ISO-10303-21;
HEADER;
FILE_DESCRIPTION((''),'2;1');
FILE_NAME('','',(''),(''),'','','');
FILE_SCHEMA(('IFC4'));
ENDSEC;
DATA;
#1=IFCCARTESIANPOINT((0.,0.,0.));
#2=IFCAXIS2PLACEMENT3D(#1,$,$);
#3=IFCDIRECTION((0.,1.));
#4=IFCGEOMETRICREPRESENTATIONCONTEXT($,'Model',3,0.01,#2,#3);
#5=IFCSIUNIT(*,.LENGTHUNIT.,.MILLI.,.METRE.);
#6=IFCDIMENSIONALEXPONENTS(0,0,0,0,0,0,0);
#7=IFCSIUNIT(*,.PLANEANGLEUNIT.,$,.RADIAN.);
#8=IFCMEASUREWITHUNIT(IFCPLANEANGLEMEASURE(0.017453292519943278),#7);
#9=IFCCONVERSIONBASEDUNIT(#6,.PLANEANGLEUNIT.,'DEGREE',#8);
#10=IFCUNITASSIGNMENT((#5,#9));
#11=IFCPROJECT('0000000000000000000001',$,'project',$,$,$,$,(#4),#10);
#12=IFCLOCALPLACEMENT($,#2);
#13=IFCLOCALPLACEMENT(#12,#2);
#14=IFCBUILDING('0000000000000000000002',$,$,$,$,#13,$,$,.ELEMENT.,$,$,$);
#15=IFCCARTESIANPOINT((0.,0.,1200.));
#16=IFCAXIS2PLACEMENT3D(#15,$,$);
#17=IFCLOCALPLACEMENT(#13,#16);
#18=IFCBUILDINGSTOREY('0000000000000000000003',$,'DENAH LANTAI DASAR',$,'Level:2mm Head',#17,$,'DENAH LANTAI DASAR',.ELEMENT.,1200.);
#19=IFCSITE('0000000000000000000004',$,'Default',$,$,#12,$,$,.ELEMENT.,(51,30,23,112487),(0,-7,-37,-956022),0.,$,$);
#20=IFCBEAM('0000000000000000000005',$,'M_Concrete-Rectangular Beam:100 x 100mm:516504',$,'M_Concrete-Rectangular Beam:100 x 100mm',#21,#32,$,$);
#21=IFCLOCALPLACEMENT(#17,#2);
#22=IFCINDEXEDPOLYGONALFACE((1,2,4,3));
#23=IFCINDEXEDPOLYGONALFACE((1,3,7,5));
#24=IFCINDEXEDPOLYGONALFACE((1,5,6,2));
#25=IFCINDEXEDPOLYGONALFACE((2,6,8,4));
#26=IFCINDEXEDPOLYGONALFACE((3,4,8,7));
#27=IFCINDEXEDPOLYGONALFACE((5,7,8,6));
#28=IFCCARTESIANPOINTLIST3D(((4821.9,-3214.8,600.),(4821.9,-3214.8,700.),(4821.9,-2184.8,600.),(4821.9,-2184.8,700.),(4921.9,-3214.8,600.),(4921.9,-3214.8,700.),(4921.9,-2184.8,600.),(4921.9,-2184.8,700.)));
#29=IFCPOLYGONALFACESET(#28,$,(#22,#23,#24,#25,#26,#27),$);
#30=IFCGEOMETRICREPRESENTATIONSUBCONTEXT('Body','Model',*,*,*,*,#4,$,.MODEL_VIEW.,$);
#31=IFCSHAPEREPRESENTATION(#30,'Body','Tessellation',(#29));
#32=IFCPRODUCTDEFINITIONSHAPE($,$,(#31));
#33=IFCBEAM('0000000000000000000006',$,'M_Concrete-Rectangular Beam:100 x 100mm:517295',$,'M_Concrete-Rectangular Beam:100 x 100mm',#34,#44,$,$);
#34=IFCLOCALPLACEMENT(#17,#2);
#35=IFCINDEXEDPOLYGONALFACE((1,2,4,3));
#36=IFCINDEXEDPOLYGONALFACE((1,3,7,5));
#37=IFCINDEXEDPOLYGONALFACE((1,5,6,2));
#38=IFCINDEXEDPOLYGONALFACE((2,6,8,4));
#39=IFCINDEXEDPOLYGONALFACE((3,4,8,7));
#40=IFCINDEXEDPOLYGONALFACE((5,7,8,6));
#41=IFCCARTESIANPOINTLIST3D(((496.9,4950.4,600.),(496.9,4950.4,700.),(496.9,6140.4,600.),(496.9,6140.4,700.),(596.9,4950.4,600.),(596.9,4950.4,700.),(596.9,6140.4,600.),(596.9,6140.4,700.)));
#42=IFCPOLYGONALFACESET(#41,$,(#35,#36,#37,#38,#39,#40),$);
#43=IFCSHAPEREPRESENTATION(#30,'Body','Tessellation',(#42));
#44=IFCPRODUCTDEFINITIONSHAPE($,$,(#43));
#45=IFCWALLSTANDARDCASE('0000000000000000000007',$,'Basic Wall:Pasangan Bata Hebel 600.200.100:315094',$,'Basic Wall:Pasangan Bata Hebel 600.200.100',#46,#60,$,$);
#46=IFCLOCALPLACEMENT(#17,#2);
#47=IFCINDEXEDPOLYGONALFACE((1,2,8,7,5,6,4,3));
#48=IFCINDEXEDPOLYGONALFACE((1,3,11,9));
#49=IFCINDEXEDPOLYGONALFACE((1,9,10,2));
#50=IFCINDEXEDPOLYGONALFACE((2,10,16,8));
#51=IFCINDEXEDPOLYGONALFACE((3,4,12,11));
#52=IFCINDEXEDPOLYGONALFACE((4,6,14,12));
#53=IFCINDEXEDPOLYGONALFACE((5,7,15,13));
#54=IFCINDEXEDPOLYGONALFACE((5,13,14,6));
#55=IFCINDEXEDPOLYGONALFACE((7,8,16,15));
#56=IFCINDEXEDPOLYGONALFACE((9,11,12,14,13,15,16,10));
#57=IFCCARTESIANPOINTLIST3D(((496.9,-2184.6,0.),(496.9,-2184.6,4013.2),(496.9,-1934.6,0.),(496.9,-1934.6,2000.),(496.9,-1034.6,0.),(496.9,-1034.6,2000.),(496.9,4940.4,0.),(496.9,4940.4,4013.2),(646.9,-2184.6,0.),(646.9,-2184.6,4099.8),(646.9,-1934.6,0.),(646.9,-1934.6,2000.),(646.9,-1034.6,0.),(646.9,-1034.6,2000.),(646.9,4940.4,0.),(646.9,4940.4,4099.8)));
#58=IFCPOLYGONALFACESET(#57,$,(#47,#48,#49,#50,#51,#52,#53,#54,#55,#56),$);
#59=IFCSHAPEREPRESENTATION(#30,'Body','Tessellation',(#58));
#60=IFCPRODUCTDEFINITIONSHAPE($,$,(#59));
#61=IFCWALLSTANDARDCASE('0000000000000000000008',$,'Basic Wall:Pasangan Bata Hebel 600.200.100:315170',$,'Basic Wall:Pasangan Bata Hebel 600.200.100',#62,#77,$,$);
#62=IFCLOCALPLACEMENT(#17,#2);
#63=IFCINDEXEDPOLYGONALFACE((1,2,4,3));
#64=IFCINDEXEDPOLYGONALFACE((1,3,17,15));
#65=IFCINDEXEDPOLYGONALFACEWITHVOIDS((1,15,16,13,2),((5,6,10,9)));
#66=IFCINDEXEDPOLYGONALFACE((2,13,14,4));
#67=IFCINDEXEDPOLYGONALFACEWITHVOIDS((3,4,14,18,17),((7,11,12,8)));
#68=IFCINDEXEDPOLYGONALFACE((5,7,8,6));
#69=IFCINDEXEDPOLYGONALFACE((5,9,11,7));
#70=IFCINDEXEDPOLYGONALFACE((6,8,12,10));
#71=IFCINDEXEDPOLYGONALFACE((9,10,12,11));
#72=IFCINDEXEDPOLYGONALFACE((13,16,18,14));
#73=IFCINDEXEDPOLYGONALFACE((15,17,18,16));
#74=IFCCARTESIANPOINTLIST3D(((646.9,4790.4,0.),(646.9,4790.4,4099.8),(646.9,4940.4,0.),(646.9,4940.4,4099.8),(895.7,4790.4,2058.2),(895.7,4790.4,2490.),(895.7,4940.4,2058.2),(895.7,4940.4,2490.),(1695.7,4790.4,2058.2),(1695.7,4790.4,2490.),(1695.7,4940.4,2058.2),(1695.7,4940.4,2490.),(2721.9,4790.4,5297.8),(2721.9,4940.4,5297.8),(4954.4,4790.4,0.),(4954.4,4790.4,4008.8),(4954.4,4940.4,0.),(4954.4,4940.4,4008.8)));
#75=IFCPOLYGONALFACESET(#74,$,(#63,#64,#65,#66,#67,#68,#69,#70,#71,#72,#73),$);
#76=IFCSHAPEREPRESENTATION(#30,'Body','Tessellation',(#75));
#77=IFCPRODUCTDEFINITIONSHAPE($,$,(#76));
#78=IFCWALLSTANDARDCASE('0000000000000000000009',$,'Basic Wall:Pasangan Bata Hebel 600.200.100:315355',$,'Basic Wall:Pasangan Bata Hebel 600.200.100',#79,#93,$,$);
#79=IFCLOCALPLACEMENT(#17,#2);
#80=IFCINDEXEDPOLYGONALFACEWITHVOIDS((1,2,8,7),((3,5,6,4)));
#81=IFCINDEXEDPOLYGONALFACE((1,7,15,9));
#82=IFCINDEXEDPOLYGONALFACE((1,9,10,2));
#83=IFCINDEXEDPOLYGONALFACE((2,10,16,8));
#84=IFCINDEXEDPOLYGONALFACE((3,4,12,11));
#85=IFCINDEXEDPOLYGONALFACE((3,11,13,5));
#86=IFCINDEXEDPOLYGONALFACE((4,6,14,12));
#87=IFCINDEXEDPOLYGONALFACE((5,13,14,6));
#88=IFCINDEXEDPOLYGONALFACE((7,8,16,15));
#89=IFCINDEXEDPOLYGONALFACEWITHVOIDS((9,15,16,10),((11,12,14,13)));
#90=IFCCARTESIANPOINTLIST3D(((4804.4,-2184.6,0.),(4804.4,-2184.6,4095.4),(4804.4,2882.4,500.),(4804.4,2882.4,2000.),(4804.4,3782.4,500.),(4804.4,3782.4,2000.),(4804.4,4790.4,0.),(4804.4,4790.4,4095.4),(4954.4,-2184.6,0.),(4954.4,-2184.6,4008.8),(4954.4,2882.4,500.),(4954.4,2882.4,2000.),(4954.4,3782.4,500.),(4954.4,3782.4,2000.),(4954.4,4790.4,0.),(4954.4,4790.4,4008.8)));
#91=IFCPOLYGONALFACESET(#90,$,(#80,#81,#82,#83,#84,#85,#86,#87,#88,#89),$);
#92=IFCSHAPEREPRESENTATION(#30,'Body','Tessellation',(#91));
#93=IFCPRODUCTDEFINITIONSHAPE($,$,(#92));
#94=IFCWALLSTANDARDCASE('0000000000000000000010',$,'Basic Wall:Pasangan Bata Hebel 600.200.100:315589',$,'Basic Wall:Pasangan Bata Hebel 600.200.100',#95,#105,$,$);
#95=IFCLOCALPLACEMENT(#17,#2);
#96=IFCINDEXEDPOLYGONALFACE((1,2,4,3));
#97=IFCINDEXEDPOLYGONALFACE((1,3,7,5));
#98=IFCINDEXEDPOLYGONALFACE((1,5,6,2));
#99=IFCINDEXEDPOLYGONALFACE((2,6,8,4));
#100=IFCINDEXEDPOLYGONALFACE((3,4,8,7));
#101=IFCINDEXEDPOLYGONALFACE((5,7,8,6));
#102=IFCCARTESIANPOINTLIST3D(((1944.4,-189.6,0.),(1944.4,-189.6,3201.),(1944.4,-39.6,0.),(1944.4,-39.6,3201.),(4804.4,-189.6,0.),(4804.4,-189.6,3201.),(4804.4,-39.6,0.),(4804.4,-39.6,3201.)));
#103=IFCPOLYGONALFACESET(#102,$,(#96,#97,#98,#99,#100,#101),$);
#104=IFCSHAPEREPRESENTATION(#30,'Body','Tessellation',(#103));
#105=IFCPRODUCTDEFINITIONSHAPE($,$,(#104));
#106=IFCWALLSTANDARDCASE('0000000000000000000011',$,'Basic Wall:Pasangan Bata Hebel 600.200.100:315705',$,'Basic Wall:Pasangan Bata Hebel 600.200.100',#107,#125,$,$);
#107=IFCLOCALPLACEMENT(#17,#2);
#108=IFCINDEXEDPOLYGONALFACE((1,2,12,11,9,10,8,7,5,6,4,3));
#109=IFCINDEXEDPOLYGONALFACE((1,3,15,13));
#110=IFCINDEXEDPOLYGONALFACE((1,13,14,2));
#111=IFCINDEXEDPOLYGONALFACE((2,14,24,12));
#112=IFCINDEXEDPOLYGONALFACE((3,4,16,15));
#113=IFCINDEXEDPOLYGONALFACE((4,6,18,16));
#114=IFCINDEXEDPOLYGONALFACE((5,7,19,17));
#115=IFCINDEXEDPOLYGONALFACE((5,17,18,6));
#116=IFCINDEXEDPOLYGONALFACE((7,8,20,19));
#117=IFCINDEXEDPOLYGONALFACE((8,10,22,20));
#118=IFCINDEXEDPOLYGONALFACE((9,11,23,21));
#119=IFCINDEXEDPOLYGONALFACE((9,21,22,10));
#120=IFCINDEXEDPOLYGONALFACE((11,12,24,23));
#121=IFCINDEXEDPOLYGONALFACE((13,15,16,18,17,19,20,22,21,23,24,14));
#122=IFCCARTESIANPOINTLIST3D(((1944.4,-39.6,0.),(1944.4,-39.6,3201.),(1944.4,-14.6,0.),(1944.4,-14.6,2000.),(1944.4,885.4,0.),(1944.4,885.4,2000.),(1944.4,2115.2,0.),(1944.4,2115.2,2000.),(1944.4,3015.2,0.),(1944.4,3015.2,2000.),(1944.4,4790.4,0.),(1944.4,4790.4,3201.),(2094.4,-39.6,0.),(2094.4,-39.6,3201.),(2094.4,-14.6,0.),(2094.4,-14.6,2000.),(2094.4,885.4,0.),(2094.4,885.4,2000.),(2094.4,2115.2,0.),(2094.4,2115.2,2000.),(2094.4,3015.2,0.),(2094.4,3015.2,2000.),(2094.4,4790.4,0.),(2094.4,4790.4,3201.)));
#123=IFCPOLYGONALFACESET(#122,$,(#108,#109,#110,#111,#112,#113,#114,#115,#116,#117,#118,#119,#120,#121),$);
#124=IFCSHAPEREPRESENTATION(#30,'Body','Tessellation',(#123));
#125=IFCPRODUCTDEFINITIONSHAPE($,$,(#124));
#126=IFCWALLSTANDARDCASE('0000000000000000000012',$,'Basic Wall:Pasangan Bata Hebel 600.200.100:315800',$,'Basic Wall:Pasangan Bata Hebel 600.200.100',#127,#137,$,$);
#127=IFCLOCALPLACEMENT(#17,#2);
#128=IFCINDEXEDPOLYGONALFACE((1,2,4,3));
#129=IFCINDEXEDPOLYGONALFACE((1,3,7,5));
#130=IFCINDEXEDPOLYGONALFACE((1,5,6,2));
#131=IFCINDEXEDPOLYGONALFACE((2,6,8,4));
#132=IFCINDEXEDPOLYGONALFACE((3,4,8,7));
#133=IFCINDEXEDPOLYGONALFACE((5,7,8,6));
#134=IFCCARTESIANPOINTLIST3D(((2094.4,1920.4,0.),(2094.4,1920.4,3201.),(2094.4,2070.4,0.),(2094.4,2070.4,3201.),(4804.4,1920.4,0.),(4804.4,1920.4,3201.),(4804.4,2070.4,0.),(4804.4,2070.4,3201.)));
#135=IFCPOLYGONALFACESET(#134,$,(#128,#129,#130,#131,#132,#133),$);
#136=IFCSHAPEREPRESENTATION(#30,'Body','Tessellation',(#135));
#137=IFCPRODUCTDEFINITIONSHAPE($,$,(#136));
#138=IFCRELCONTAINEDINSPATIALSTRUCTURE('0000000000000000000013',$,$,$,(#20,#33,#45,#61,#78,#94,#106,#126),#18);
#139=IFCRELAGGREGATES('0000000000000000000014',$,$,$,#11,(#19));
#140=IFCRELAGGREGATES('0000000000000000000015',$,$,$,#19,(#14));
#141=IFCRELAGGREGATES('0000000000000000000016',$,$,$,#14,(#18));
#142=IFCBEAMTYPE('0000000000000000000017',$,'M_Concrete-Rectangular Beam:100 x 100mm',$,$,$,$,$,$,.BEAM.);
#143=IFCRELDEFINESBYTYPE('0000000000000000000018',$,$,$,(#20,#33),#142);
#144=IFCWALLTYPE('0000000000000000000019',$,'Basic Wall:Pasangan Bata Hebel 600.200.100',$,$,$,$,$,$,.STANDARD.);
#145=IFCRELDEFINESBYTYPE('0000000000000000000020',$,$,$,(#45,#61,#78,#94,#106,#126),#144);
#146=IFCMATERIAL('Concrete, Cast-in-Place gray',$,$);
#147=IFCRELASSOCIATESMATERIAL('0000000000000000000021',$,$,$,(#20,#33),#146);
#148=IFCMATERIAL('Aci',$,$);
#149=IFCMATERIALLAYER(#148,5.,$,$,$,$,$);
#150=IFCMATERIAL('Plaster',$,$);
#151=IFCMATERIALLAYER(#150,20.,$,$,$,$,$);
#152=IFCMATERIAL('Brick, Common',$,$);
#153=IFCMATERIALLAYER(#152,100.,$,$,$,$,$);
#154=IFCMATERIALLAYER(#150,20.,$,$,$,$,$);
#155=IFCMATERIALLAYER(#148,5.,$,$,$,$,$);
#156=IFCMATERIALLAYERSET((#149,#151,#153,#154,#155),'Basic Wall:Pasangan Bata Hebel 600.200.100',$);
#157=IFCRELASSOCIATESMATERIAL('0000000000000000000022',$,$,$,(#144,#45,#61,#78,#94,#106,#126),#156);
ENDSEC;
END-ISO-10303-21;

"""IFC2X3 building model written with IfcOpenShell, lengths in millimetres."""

from ifc_helpers import new_model, entity, si_unit, converted_unit, direction, frame, frame_2d, origin, place, context, subcontext, project, spatial, polyline, rectangle, extrude, clip, bounded_halfspace, material, layer, layer_set, layer_usage, type_object, element, save


model = new_model("IFC2X3")

# Units and contexts
model_context = context("Model", 3, precision=0.01, world=origin(), true_north=direction((0.0, 1.0)))
body_context = subcontext(model_context, "Body", "Model", "MODEL_VIEW")
ifc_project = project(units=[si_unit("LENGTHUNIT", "METRE", prefix="MILLI"), converted_unit("PLANEANGLEUNIT", "DEGREE", entity("IfcPlaneAngleMeasure", 0.017453292519943278), si_unit("PLANEANGLEUNIT", "RADIAN"), dimensions=[0, 0, 0, 0, 0, 0, 0])], contexts=[model_context])

# Site, building, storey
site_placement = place(None, origin())
site = spatial("IfcSite", under=ifc_project, at=site_placement, Name="Default", CompositionType="ELEMENT", RefLatitude=(51, 30, 23, 112487), RefLongitude=(0, -7, -37, -956022), RefElevation=0.0)
building_placement = place(site_placement, origin())
building = spatial("IfcBuilding", under=site, at=building_placement, CompositionType="ELEMENT")
storey_placement = place(building_placement, frame((0.0, 0.0, 1200.0)))
storey = spatial("IfcBuildingStorey", under=building, at=storey_placement, Name="DENAH LANTAI DASAR", ObjectType="Level:2mm Head", LongName="DENAH LANTAI DASAR", CompositionType="ELEMENT", Elevation=1200.0)

# Beams
ifc_material_1 = material(Name="Concrete, Cast-in-Place gray")
beam_type = type_object("IfcBeamType", Name="M_Concrete-Rectangular Beam:100 x 100mm", PredefinedType="BEAM")
beam_1_placement = place(storey_placement, frame((4871.9, -2184.8, 700.0), z_axis=(0.0, 0.0, 1.0), x_axis=(0.0, -1.0, 0.0)))
element("IfcBeam", 1, at=beam_1_placement, inside=storey, type_object=beam_type, material=ifc_material_1, Name="M_Concrete-Rectangular Beam:100 x 100mm:516504", ObjectType="M_Concrete-Rectangular Beam:100 x 100mm", context=body_context, shape_type="SweptSolid", body=[
    extrude(rectangle(XDim=100.0, YDim=100.0, at=frame_2d((0.0, 0.0), x_axis=(1.0, 0.0))), frame((0.0, 0.0, -50.0), z_axis=(1.0, 0.0, 0.0), x_axis=(0.0, 0.0, -1.0)), (0.0, 0.0, 1.0), 1030.0),
])
beam_2_placement = place(storey_placement, frame((546.9, 4950.4, 700.0), z_axis=(0.0, 0.0, 1.0), x_axis=(0.0, 1.0, 0.0)))
element("IfcBeam", 2, at=beam_2_placement, inside=storey, type_object=beam_type, material=ifc_material_1, Name="M_Concrete-Rectangular Beam:100 x 100mm:517295", ObjectType="M_Concrete-Rectangular Beam:100 x 100mm", context=body_context, shape_type="SweptSolid", body=[
    extrude(rectangle(XDim=100.0, YDim=100.0, at=frame_2d((0.0, 0.0), x_axis=(1.0, 0.0))), frame((0.0, 0.0, -50.0), z_axis=(1.0, 0.0, 0.0), x_axis=(0.0, 0.0, -1.0)), (0.0, 0.0, 1.0), 1190.0),
])

# Walls, openings
ifc_material_2 = material(Name="Aci")
ifc_layer_1 = layer(ifc_material_2, 5.0)
ifc_material_3 = material(Name="Plaster")
ifc_layer_2 = layer(ifc_material_3, 20.0)
ifc_material_4 = material(Name="Brick, Common")
ifc_layer_3 = layer(ifc_material_4, 100.0)
ifc_layer_4 = layer(ifc_material_3, 20.0)
ifc_layer_5 = layer(ifc_material_2, 5.0)
ifc_layer_set = layer_set([ifc_layer_1, ifc_layer_2, ifc_layer_3, ifc_layer_4, ifc_layer_5], Name="Basic Wall:Pasangan Bata Hebel 600.200.100")
ifc_layer_usage_1 = layer_usage(ifc_layer_set, "AXIS2", "NEGATIVE", 75.0)
wall_type = type_object("IfcWallType", Name="Basic Wall:Pasangan Bata Hebel 600.200.100", PredefinedType="STANDARD", material=ifc_layer_set)
wall_1_placement = place(storey_placement, frame((571.9, -2184.6, 0.0), z_axis=(0.0, 0.0, 1.0), x_axis=(0.0, 1.0, 0.0)))
wall_1 = element("IfcWallStandardCase", 3, at=wall_1_placement, inside=storey, type_object=wall_type, material=ifc_layer_usage_1, Name="Basic Wall:Pasangan Bata Hebel 600.200.100:315094", ObjectType="Basic Wall:Pasangan Bata Hebel 600.200.100", context=body_context, shape_type="Clipping", body=[
    clip(extrude(rectangle(XDim=7125.0, YDim=150.0, at=frame_2d((3562.5, 0.0), x_axis=(1.0, 0.0))), origin(), (0.0, 0.0, 1.0), 4099.8), bounded_halfspace(frame((0.0, -75.0, 4099.8), z_axis=(0.0, 0.5, 0.866025), x_axis=(-1.0, 0.0, 0.0)), False, frame((0.0, -75.0, 4099.8)), polyline([(0.0, 0.0), (150.0, 0.0), (6975.0, 0.0), (7125.0, 0.0), (7125.0, 150.0), (0.0, 150.0), (0.0, 0.0)]))),
])
opening_1_placement = place(wall_1_placement, frame((1150.0, 75.0, 0.0)))
element("IfcOpeningElement", 4, at=opening_1_placement, cuts=wall_1, ObjectType="Opening", context=body_context, shape_type="SweptSolid", body=[
    extrude(rectangle(XDim=2000.0, YDim=900.0, at=frame_2d((1000.0, 450.0), x_axis=(1.0, 0.0))), frame((0.0, 0.0, 0.0), z_axis=(0.0, -1.0, 0.0), x_axis=(0.0, 0.0, 1.0)), (0.0, 0.0, 1.0), 150.0),
])
ifc_layer_usage_2 = layer_usage(ifc_layer_set, "AXIS2", "NEGATIVE", 75.0)
wall_2_placement = place(storey_placement, frame((646.9, 4865.4, 0.0)))
wall_2 = element("IfcWallStandardCase", 5, at=wall_2_placement, inside=storey, type_object=wall_type, material=ifc_layer_usage_2, Name="Basic Wall:Pasangan Bata Hebel 600.200.100:315170", ObjectType="Basic Wall:Pasangan Bata Hebel 600.200.100", context=body_context, shape_type="Clipping", body=[
    clip(clip(extrude(rectangle(XDim=4307.5, YDim=150.0, at=frame_2d((2153.7, 0.0), x_axis=(-1.0, 0.0))), origin(), (0.0, 0.0, 1.0), 5297.8), bounded_halfspace(frame((2075.0, -75.0, 5297.8), z_axis=(0.5, 0.0, 0.866025), x_axis=(0.0, 1.0, 0.0)), False, frame((2075.0, -75.0, 5297.8)), polyline([(0.0, 0.0), (2082.5, 0.0), (2232.5, 0.0), (2232.5, 150.0), (0.0, 150.0), (0.0, 0.0)]))), bounded_halfspace(frame((0.0, -75.0, 4099.8), z_axis=(-0.5, 0.0, 0.866025), x_axis=(0.0, -1.0, 0.0)), False, frame((0.0, -75.0, 4099.8)), polyline([(0.0, 0.0), (2075.0, 0.0), (2075.0, 150.0), (0.0, 150.0), (0.0, 0.0)]))),
])
opening_2_placement = place(wall_2_placement, frame((248.7, -75.0, 2058.2)))
element("IfcOpeningElement", 6, at=opening_2_placement, cuts=wall_2, ObjectType="Opening", context=body_context, shape_type="SweptSolid", body=[
    extrude(rectangle(XDim=431.8, YDim=800.0, at=frame_2d((215.9, 400.0), x_axis=(-1.0, 0.0))), frame((0.0, 0.0, 0.0), z_axis=(0.0, 1.0, 0.0), x_axis=(0.0, 0.0, 1.0)), (0.0, 0.0, 1.0), 150.0),
])
ifc_layer_usage_3 = layer_usage(ifc_layer_set, "AXIS2", "NEGATIVE", 75.0)
wall_3_placement = place(storey_placement, frame((4879.4, 4790.4, 0.0), z_axis=(0.0, 0.0, 1.0), x_axis=(0.0, -1.0, 0.0)))
wall_3 = element("IfcWallStandardCase", 7, at=wall_3_placement, inside=storey, type_object=wall_type, material=ifc_layer_usage_3, Name="Basic Wall:Pasangan Bata Hebel 600.200.100:315355", ObjectType="Basic Wall:Pasangan Bata Hebel 600.200.100", context=body_context, shape_type="Clipping", body=[
    clip(extrude(rectangle(XDim=6975.0, YDim=150.0, at=frame_2d((3487.5, 0.0), x_axis=(-1.0, 0.0))), origin(), (0.0, 0.0, 1.0), 4095.4), bounded_halfspace(frame((0.0, -75.0, 4095.4), z_axis=(0.0, 0.5, 0.866025), x_axis=(-1.0, 0.0, 0.0)), False, frame((0.0, -75.0, 4095.4)), polyline([(0.0, 0.0), (6825.0, 0.0), (6975.0, 0.0), (6975.0, 150.0), (0.0, 150.0), (0.0, 0.0)]))),
])
opening_3_placement = place(wall_3_placement, frame((4790.4, -4879.4, 0.0), z_axis=(0.0, 0.0, 1.0), x_axis=(0.0, 1.0, 0.0)))
element("IfcOpeningElement", 8, at=opening_3_placement, cuts=wall_3, ObjectType="Opening", context=body_context, shape_type="SweptSolid", body=[
    extrude(rectangle(XDim=1500.0, YDim=900.0, at=frame_2d((0.0, 0.0), x_axis=(0.0, 1.0))), frame((4804.4, 3332.4, 1250.0), z_axis=(1.0, 0.0, 0.0), x_axis=(0.0, -1.0, 0.0)), (0.0, 0.0, 1.0), 150.0),
])

# Wall
ifc_layer_usage_4 = layer_usage(ifc_layer_set, "AXIS2", "NEGATIVE", 75.0)
wall_4_placement = place(storey_placement, frame((4804.4, -114.6, 0.0), z_axis=(0.0, 0.0, 1.0), x_axis=(-1.0, 0.0, 0.0)))
element("IfcWallStandardCase", 9, at=wall_4_placement, inside=storey, type_object=wall_type, material=ifc_layer_usage_4, Name="Basic Wall:Pasangan Bata Hebel 600.200.100:315589", ObjectType="Basic Wall:Pasangan Bata Hebel 600.200.100", context=body_context, shape_type="SweptSolid", body=[
    extrude(rectangle(XDim=2860.0, YDim=150.0, at=frame_2d((1430.0, 0.0), x_axis=(-1.0, 0.0))), origin(), (0.0, 0.0, 1.0), 3201.0),
])

# Wall, openings
ifc_layer_usage_5 = layer_usage(ifc_layer_set, "AXIS2", "NEGATIVE", 75.0)
wall_5_placement = place(storey_placement, frame((2019.4, -39.6, 0.0), z_axis=(0.0, 0.0, 1.0), x_axis=(0.0, 1.0, 0.0)))
wall_5 = element("IfcWallStandardCase", 10, at=wall_5_placement, inside=storey, type_object=wall_type, material=ifc_layer_usage_5, Name="Basic Wall:Pasangan Bata Hebel 600.200.100:315705", ObjectType="Basic Wall:Pasangan Bata Hebel 600.200.100", context=body_context, shape_type="SweptSolid", body=[
    extrude(rectangle(XDim=4830.0, YDim=150.0, at=frame_2d((2415.0, 0.0), x_axis=(1.0, 0.0))), origin(), (0.0, 0.0, 1.0), 3201.0),
])
opening_4_placement = place(wall_5_placement, frame((25.0, -75.0, 0.0)))
element("IfcOpeningElement", 11, at=opening_4_placement, cuts=wall_5, ObjectType="Opening", context=body_context, shape_type="SweptSolid", body=[
    extrude(rectangle(XDim=2000.0, YDim=900.0, at=frame_2d((1000.0, 450.0), x_axis=(1.0, 0.0))), frame((0.0, 0.0, 0.0), z_axis=(0.0, 1.0, 0.0), x_axis=(0.0, 0.0, 1.0)), (0.0, 0.0, 1.0), 150.0),
])
opening_5_placement = place(wall_5_placement, frame((3054.8, 75.0, 0.0)))
element("IfcOpeningElement", 12, at=opening_5_placement, cuts=wall_5, ObjectType="Opening", context=body_context, shape_type="SweptSolid", body=[
    extrude(rectangle(XDim=2000.0, YDim=900.0, at=frame_2d((1000.0, 450.0), x_axis=(1.0, 0.0))), frame((0.0, 0.0, 0.0), z_axis=(0.0, -1.0, 0.0), x_axis=(0.0, 0.0, 1.0)), (0.0, 0.0, 1.0), 150.0),
])

# Wall
ifc_layer_usage_6 = layer_usage(ifc_layer_set, "AXIS2", "NEGATIVE", 75.0)
wall_6_placement = place(storey_placement, frame((2094.4, 1995.4, 0.0)))
element("IfcWallStandardCase", 13, at=wall_6_placement, inside=storey, type_object=wall_type, material=ifc_layer_usage_6, Name="Basic Wall:Pasangan Bata Hebel 600.200.100:315800", ObjectType="Basic Wall:Pasangan Bata Hebel 600.200.100", context=body_context, shape_type="SweptSolid", body=[
    extrude(rectangle(XDim=2710.0, YDim=150.0, at=frame_2d((1355.0, 0.0), x_axis=(-1.0, 0.0))), origin(), (0.0, 0.0, 1.0), 3201.0),
])

save(model, "model.ifc")
